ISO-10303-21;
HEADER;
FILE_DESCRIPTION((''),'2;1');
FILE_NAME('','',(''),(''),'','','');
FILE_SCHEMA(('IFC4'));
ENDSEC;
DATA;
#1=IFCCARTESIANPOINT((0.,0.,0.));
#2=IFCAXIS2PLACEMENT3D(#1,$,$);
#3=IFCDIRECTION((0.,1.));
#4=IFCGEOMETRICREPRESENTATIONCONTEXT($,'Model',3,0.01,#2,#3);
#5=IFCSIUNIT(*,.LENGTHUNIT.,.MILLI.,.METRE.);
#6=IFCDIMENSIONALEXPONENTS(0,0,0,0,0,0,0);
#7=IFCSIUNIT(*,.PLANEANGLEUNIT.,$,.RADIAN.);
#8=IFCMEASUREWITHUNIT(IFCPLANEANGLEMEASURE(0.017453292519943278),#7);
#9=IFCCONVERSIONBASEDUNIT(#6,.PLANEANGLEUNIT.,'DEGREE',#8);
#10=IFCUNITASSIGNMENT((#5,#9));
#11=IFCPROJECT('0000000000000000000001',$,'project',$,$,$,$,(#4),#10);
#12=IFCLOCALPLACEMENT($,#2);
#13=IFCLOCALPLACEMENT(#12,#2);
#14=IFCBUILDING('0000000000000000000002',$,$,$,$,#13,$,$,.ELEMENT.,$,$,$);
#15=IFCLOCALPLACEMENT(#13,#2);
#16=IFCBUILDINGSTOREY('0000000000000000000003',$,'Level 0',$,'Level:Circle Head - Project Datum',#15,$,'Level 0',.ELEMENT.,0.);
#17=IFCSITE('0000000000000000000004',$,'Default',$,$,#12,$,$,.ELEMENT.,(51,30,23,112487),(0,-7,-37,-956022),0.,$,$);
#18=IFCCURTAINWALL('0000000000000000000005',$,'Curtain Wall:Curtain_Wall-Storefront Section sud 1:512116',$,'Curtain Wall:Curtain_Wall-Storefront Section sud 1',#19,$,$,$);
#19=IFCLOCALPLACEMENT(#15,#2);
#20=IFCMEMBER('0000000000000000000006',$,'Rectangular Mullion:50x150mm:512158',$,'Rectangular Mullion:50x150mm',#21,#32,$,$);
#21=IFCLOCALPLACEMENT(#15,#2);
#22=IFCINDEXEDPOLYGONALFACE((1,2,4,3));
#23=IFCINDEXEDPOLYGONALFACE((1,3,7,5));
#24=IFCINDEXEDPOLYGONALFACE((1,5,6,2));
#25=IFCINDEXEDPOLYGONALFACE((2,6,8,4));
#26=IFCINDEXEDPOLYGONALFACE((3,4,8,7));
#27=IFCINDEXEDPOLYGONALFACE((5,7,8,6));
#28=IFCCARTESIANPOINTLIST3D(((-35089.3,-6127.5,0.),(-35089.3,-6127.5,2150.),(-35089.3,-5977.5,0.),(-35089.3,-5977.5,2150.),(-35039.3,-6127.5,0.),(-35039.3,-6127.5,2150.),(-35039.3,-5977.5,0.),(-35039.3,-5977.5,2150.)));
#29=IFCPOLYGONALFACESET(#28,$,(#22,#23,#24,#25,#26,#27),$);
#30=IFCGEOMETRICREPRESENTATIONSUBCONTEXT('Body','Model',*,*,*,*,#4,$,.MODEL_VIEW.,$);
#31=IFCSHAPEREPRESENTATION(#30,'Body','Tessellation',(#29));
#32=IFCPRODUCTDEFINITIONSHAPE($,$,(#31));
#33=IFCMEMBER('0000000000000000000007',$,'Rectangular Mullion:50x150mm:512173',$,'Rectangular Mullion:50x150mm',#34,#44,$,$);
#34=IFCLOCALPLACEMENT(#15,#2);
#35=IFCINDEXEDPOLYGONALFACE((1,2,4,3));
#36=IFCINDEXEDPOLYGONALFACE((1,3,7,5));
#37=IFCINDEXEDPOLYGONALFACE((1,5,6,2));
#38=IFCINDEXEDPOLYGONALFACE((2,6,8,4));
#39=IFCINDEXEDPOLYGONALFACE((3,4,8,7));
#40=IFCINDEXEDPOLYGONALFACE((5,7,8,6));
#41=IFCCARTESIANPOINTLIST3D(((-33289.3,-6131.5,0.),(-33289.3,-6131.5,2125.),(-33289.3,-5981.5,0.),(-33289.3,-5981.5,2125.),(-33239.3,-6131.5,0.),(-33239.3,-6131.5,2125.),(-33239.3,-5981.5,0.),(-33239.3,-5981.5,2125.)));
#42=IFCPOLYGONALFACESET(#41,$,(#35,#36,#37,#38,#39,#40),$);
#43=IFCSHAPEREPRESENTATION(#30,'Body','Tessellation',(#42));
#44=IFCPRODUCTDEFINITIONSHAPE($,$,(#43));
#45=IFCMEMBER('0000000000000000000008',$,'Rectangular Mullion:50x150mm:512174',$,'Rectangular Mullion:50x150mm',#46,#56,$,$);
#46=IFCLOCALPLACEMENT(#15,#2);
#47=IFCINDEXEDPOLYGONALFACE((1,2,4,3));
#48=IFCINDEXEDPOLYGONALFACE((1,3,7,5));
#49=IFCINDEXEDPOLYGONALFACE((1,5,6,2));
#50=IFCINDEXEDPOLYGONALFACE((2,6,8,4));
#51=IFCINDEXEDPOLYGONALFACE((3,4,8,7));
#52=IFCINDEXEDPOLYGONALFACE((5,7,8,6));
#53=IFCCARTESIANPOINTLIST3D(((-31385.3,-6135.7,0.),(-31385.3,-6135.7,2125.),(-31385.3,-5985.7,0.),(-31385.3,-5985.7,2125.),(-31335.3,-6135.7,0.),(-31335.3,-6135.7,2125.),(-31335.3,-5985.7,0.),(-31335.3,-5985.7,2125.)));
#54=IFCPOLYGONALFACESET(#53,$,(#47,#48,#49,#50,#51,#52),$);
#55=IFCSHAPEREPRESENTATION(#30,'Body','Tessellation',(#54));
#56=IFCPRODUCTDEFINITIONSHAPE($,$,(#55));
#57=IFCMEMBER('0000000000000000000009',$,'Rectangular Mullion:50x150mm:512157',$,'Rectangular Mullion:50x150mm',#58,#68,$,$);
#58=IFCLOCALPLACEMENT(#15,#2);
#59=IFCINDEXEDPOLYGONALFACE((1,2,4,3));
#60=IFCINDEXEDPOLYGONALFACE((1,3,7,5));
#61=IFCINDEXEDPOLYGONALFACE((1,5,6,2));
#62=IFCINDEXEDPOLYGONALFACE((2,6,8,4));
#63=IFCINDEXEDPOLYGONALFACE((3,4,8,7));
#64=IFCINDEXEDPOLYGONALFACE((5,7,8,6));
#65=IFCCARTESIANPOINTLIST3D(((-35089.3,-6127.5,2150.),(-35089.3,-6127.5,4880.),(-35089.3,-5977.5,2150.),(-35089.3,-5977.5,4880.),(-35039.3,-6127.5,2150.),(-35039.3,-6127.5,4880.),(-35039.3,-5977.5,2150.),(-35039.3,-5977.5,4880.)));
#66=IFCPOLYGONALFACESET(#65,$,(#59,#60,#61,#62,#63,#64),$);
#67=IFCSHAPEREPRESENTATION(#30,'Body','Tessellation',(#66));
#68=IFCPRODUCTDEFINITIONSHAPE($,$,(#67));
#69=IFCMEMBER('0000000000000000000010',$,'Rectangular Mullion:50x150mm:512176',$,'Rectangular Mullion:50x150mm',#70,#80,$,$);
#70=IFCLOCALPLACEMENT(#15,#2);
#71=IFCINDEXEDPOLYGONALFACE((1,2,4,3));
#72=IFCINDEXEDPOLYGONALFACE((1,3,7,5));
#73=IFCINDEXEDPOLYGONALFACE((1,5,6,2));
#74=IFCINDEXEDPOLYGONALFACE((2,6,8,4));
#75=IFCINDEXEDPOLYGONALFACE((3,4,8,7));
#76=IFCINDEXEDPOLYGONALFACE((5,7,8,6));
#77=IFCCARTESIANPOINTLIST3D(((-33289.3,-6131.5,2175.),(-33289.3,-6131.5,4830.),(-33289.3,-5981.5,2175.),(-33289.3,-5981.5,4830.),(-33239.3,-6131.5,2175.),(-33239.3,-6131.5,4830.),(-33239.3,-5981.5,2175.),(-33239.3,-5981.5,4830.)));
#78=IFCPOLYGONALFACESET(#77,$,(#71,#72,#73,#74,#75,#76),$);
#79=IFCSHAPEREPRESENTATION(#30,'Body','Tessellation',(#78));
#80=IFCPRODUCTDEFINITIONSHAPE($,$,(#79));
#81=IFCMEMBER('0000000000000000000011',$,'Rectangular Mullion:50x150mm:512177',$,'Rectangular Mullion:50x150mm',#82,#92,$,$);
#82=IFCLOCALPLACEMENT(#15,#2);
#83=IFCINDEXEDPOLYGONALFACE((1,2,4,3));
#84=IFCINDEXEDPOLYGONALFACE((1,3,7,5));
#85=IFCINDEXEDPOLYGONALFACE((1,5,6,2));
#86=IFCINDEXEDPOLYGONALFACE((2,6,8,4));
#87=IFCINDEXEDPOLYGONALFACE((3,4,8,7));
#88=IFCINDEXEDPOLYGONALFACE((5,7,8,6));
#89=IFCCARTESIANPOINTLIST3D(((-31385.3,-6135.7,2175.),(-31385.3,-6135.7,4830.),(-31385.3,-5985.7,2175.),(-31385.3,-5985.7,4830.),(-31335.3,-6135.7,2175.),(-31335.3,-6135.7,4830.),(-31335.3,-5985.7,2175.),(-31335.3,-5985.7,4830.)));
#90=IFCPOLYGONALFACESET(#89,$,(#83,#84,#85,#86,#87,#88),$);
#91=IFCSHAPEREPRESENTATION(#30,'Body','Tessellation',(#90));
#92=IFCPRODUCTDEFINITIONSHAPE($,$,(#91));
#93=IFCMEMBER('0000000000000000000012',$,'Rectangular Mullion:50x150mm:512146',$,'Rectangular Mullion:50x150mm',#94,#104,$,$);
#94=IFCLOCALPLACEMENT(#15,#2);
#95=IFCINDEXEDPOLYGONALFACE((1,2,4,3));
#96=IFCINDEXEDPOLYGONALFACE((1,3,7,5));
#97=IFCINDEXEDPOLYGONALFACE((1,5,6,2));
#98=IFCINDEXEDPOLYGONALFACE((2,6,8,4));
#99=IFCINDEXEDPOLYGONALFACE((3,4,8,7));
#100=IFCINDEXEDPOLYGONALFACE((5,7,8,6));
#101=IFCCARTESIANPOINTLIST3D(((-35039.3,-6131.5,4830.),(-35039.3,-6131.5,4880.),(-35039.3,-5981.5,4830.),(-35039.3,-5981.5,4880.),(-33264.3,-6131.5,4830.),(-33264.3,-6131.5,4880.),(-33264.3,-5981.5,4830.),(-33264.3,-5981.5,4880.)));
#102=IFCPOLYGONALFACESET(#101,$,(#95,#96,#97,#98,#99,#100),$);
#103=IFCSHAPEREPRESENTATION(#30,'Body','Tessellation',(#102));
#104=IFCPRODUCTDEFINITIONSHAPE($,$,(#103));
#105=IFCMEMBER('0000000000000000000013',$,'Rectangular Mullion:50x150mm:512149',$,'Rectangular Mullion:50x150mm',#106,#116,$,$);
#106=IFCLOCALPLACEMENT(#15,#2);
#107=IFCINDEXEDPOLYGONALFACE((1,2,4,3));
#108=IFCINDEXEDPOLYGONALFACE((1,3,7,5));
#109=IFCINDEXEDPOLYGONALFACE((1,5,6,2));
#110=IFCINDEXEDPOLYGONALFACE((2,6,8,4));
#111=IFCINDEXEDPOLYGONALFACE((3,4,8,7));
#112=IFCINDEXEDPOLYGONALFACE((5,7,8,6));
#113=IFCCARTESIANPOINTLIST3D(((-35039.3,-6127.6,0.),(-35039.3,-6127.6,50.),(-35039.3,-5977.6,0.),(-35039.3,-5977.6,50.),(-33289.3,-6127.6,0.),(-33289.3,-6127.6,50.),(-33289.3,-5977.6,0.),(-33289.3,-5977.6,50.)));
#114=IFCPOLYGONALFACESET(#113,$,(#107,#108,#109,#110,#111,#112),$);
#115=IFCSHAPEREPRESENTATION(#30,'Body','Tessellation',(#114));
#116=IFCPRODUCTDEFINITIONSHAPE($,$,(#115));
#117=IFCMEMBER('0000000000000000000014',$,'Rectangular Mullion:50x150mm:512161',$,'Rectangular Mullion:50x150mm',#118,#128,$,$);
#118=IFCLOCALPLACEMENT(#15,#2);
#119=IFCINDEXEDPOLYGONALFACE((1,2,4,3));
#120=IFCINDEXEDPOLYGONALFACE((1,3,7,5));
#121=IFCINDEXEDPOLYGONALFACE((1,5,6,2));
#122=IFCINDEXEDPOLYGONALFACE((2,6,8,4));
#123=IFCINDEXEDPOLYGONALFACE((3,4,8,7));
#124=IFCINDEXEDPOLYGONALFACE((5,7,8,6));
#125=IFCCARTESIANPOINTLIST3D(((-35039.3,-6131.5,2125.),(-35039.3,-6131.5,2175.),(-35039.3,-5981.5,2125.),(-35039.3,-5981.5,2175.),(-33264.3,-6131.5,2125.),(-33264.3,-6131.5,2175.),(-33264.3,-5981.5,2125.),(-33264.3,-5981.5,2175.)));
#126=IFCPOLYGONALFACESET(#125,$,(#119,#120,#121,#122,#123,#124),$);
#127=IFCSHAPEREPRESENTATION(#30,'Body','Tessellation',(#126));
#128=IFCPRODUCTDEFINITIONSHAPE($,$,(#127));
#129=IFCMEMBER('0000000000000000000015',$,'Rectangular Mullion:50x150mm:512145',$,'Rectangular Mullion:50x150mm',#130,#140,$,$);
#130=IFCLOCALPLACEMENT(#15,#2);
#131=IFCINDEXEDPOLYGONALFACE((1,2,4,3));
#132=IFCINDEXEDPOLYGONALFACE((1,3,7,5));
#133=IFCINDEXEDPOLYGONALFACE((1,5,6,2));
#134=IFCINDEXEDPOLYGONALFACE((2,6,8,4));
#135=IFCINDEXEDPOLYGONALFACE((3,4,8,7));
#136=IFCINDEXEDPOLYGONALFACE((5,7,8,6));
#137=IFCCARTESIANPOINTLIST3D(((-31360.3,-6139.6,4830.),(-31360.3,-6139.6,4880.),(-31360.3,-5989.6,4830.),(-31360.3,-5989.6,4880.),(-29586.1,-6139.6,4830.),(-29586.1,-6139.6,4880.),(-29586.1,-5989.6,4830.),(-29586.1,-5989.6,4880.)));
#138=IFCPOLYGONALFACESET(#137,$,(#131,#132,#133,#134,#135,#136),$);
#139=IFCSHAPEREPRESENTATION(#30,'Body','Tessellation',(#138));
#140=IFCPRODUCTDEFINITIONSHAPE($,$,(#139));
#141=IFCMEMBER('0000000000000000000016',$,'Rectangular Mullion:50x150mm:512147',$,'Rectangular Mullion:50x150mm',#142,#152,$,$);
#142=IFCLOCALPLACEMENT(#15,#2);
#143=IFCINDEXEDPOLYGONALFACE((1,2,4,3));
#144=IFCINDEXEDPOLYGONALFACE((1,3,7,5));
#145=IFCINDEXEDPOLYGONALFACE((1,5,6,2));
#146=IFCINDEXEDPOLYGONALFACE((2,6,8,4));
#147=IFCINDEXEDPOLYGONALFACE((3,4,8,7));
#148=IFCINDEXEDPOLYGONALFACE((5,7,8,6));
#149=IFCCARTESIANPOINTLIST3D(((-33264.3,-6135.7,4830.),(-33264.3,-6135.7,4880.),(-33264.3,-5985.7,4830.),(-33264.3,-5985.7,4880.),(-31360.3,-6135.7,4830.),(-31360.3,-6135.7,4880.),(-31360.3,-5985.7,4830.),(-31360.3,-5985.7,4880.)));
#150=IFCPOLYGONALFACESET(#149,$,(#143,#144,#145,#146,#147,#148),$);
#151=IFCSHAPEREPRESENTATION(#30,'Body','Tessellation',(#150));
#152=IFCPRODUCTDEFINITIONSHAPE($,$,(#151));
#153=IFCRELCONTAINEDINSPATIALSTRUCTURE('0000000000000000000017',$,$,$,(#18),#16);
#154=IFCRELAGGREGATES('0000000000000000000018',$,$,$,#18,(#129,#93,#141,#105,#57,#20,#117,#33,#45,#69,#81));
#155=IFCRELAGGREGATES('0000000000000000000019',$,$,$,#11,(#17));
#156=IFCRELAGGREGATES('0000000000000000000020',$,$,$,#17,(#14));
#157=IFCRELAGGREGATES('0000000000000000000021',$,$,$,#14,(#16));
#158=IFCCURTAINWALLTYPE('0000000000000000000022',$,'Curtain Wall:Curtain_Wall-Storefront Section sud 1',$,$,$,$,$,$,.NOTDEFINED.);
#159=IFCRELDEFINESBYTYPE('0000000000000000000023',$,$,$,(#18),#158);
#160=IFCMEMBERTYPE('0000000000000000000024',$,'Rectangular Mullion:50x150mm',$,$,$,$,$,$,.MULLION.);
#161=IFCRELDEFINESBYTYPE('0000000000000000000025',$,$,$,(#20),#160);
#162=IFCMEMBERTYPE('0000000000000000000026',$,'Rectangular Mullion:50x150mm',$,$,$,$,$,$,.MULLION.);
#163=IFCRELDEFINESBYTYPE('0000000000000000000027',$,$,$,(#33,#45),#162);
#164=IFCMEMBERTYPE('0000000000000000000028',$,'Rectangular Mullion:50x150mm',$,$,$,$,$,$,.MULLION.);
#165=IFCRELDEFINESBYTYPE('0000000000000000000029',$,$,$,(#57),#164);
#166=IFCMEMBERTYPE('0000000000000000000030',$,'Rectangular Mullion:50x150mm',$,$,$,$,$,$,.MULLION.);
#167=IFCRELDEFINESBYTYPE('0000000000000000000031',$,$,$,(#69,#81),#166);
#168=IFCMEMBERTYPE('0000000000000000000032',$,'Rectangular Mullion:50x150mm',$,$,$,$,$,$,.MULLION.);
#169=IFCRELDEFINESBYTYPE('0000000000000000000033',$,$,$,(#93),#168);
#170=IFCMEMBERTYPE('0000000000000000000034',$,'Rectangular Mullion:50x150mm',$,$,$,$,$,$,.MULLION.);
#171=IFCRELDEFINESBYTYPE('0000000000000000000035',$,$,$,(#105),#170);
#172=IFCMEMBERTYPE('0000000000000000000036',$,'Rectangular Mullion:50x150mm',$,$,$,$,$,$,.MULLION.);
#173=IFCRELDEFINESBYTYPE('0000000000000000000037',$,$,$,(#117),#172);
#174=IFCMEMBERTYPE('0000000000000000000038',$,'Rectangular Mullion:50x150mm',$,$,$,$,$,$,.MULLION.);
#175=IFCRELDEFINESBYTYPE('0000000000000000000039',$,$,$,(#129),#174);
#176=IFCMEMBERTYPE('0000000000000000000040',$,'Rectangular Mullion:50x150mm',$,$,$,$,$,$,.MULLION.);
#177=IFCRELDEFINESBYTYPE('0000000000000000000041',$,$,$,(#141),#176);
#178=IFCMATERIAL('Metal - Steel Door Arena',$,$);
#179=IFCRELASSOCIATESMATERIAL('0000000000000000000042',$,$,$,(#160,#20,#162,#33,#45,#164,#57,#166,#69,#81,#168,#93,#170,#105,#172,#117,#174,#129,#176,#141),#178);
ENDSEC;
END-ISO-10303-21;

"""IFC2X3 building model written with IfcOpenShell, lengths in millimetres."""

from ifc_helpers import new_model, entity, si_unit, converted_unit, direction, frame, origin, origin_2d_with_axis, place, context, subcontext, project, spatial, rectangle, extrude, source, transform, mapped, material, type_object, type_shapes, element, aggregate, save


model = new_model("IFC2X3")

# Units and contexts
model_context = context("Model", 3, precision=0.01, world=origin(), true_north=direction((0.0, 1.0)))
body_context = subcontext(model_context, "Body", "Model", "MODEL_VIEW")
ifc_project = project(units=[si_unit("LENGTHUNIT", "METRE", prefix="MILLI"), converted_unit("PLANEANGLEUNIT", "DEGREE", entity("IfcPlaneAngleMeasure", 0.017453292519943278), si_unit("PLANEANGLEUNIT", "RADIAN"), dimensions=[0, 0, 0, 0, 0, 0, 0])], contexts=[model_context])

# Site, building, storey
site_placement = place(None, origin())
site = spatial("IfcSite", under=ifc_project, at=site_placement, Name="Default", CompositionType="ELEMENT", RefLatitude=(51, 30, 23, 112487), RefLongitude=(0, -7, -37, -956022), RefElevation=0.0)
building_placement = place(site_placement, origin())
building = spatial("IfcBuilding", under=site, at=building_placement, CompositionType="ELEMENT")
storey_placement = place(building_placement, origin())
storey = spatial("IfcBuildingStorey", under=building, at=storey_placement, Name="Level 0", ObjectType="Level:Circle Head - Project Datum", LongName="Level 0", CompositionType="ELEMENT", Elevation=0.0)

# Curtain wall, members
curtain_wall_type = type_object("IfcCurtainWallType", Name="Curtain Wall:Curtain_Wall-Storefront Section sud 1", PredefinedType="NOTDEFINED")
curtain_wall_placement = place(storey_placement, origin())
curtain_wall = element("IfcCurtainWall", 1, at=curtain_wall_placement, inside=storey, type_object=curtain_wall_type, Name="Curtain Wall:Curtain_Wall-Storefront Section sud 1:512116", ObjectType="Curtain Wall:Curtain_Wall-Storefront Section sud 1")
ifc_material_1 = material(Name="Metal - Steel Door Arena")
member_type_1 = type_object("IfcMemberType", Name="Rectangular Mullion:50x150mm", PredefinedType="MULLION", material=ifc_material_1)
shared_shape_1 = source(origin(), body_context, "Body", "SweptSolid", [
    extrude(rectangle(XDim=50.0, YDim=150.0, at=origin_2d_with_axis()), frame((-25.0, 0.0, -2150.0), z_axis=(0.0, 0.0, 1.0), x_axis=(-1.0, 0.0, 0.0)), (0.0, 0.0, 1.0), 2150.0),
])
type_shapes(member_type_1, [shared_shape_1])
member_1_placement = place(curtain_wall_placement, frame((-35089.3, -6052.5, 2150.0), z_axis=(0.0, 0.0, 1.0), x_axis=(-1.0, 0.0, 0.0)))
member_1 = element("IfcMember", 2, at=member_1_placement, type_object=member_type_1, material=ifc_material_1, Name="Rectangular Mullion:50x150mm:512158", ObjectType="Rectangular Mullion:50x150mm", context=body_context, shape_type="MappedRepresentation", body=[
    mapped(shared_shape_1, transform((0.0, 0.0, 0.0), scale=1.0)),
])
member_type_2 = type_object("IfcMemberType", Name="Rectangular Mullion:50x150mm", PredefinedType="MULLION", material=ifc_material_1)
shared_shape_2 = source(origin(), body_context, "Body", "SweptSolid", [
    extrude(rectangle(XDim=50.0, YDim=150.0, at=origin_2d_with_axis()), frame((0.0, 0.0, -2125.0), z_axis=(0.0, 0.0, 1.0), x_axis=(-1.0, 0.0, 0.0)), (0.0, 0.0, 1.0), 2125.0),
])
type_shapes(member_type_2, [shared_shape_2])
member_2_placement = place(curtain_wall_placement, frame((-33264.3, -6056.5, 0.0), z_axis=(0.0, 0.0, -1.0), x_axis=(1.0, 0.0, 0.0)))
member_2 = element("IfcMember", 3, at=member_2_placement, type_object=member_type_2, material=ifc_material_1, Name="Rectangular Mullion:50x150mm:512173", ObjectType="Rectangular Mullion:50x150mm", context=body_context, shape_type="MappedRepresentation", body=[
    mapped(shared_shape_2, transform((0.0, 0.0, 0.0), scale=1.0)),
])
member_3_placement = place(curtain_wall_placement, frame((-31360.3, -6060.7, 0.0), z_axis=(0.0, 0.0, -1.0), x_axis=(1.0, 0.0, 0.0)))
member_3 = element("IfcMember", 4, at=member_3_placement, type_object=member_type_2, material=ifc_material_1, Name="Rectangular Mullion:50x150mm:512174", ObjectType="Rectangular Mullion:50x150mm", context=body_context, shape_type="MappedRepresentation", body=[
    mapped(shared_shape_2, transform((0.0, 0.0, 0.0), scale=1.0)),
])
member_type_3 = type_object("IfcMemberType", Name="Rectangular Mullion:50x150mm", PredefinedType="MULLION", material=ifc_material_1)
shared_shape_3 = source(origin(), body_context, "Body", "SweptSolid", [
    extrude(rectangle(XDim=50.0, YDim=150.0, at=origin_2d_with_axis()), frame((-25.0, 0.0, -2730.0), z_axis=(0.0, 0.0, 1.0), x_axis=(-1.0, 0.0, 0.0)), (0.0, 0.0, 1.0), 2730.0),
])
type_shapes(member_type_3, [shared_shape_3])
member_4_placement = place(curtain_wall_placement, frame((-35089.3, -6052.5, 4880.0), z_axis=(0.0, 0.0, 1.0), x_axis=(-1.0, 0.0, 0.0)))
member_4 = element("IfcMember", 5, at=member_4_placement, type_object=member_type_3, material=ifc_material_1, Name="Rectangular Mullion:50x150mm:512157", ObjectType="Rectangular Mullion:50x150mm", context=body_context, shape_type="MappedRepresentation", body=[
    mapped(shared_shape_3, transform((0.0, 0.0, 0.0), scale=1.0)),
])
member_type_4 = type_object("IfcMemberType", Name="Rectangular Mullion:50x150mm", PredefinedType="MULLION", material=ifc_material_1)
shared_shape_4 = source(origin(), body_context, "Body", "SweptSolid", [
    extrude(rectangle(XDim=50.0, YDim=150.0, at=origin_2d_with_axis()), frame((0.0, 0.0, -2655.0), z_axis=(0.0, 0.0, 1.0), x_axis=(-1.0, 0.0, 0.0)), (0.0, 0.0, 1.0), 2655.0),
])
type_shapes(member_type_4, [shared_shape_4])
member_5_placement = place(curtain_wall_placement, frame((-33264.3, -6056.5, 2175.0), z_axis=(0.0, 0.0, -1.0), x_axis=(1.0, 0.0, 0.0)))
member_5 = element("IfcMember", 6, at=member_5_placement, type_object=member_type_4, material=ifc_material_1, Name="Rectangular Mullion:50x150mm:512176", ObjectType="Rectangular Mullion:50x150mm", context=body_context, shape_type="MappedRepresentation", body=[
    mapped(shared_shape_4, transform((0.0, 0.0, 0.0), scale=1.0)),
])
member_6_placement = place(curtain_wall_placement, frame((-31360.3, -6060.7, 2175.0), z_axis=(0.0, 0.0, -1.0), x_axis=(1.0, 0.0, 0.0)))
member_6 = element("IfcMember", 7, at=member_6_placement, type_object=member_type_4, material=ifc_material_1, Name="Rectangular Mullion:50x150mm:512177", ObjectType="Rectangular Mullion:50x150mm", context=body_context, shape_type="MappedRepresentation", body=[
    mapped(shared_shape_4, transform((0.0, 0.0, 0.0), scale=1.0)),
])
member_type_5 = type_object("IfcMemberType", Name="Rectangular Mullion:50x150mm", PredefinedType="MULLION", material=ifc_material_1)
shared_shape_5 = source(origin(), body_context, "Body", "SweptSolid", [
    extrude(rectangle(XDim=50.0, YDim=150.0, at=origin_2d_with_axis()), frame((-25.0, 0.0, -1775.0), z_axis=(0.0, 0.0, 1.0), x_axis=(-1.0, 0.0, 0.0)), (0.0, 0.0, 1.0), 1775.0),
])
type_shapes(member_type_5, [shared_shape_5])
member_7_placement = place(curtain_wall_placement, frame((-33264.3, -6056.5, 4880.0), z_axis=(1.0, 0.0, 0.0), x_axis=(0.0, 0.0, 1.0)))
member_7 = element("IfcMember", 8, at=member_7_placement, type_object=member_type_5, material=ifc_material_1, Name="Rectangular Mullion:50x150mm:512146", ObjectType="Rectangular Mullion:50x150mm", context=body_context, shape_type="MappedRepresentation", body=[
    mapped(shared_shape_5, transform((0.0, 0.0, 0.0), scale=1.0)),
])
member_type_6 = type_object("IfcMemberType", Name="Rectangular Mullion:50x150mm", PredefinedType="MULLION", material=ifc_material_1)
shared_shape_6 = source(origin(), body_context, "Body", "SweptSolid", [
    extrude(rectangle(XDim=50.0, YDim=150.0, at=origin_2d_with_axis()), frame((-25.0, 0.0, -1750.0), z_axis=(0.0, 0.0, 1.0), x_axis=(-1.0, 0.0, 0.0)), (0.0, 0.0, 1.0), 1750.0),
])
type_shapes(member_type_6, [shared_shape_6])
member_8_placement = place(curtain_wall_placement, frame((-35039.3, -6052.6, 0.0), z_axis=(-1.0, 0.0, 0.0), x_axis=(0.0, 0.0, -1.0)))
member_8 = element("IfcMember", 9, at=member_8_placement, type_object=member_type_6, material=ifc_material_1, Name="Rectangular Mullion:50x150mm:512149", ObjectType="Rectangular Mullion:50x150mm", context=body_context, shape_type="MappedRepresentation", body=[
    mapped(shared_shape_6, transform((0.0, 0.0, 0.0), scale=1.0)),
])
member_type_7 = type_object("IfcMemberType", Name="Rectangular Mullion:50x150mm", PredefinedType="MULLION", material=ifc_material_1)
shared_shape_7 = source(origin(), body_context, "Body", "SweptSolid", [
    extrude(rectangle(XDim=50.0, YDim=150.0, at=origin_2d_with_axis()), frame((0.0, 0.0, -1775.0), z_axis=(0.0, 0.0, 1.0), x_axis=(-1.0, 0.0, 0.0)), (0.0, 0.0, 1.0), 1775.0),
])
type_shapes(member_type_7, [shared_shape_7])
member_9_placement = place(curtain_wall_placement, frame((-33264.3, -6056.5, 2150.0), z_axis=(1.0, 0.0, 0.0), x_axis=(0.0, 0.0, 1.0)))
member_9 = element("IfcMember", 10, at=member_9_placement, type_object=member_type_7, material=ifc_material_1, Name="Rectangular Mullion:50x150mm:512161", ObjectType="Rectangular Mullion:50x150mm", context=body_context, shape_type="MappedRepresentation", body=[
    mapped(shared_shape_7, transform((0.0, 0.0, 0.0), scale=1.0)),
])
member_type_8 = type_object("IfcMemberType", Name="Rectangular Mullion:50x150mm", PredefinedType="MULLION", material=ifc_material_1)
shared_shape_8 = source(origin(), body_context, "Body", "SweptSolid", [
    extrude(rectangle(XDim=50.0, YDim=150.0, at=origin_2d_with_axis()), frame((-25.0, 0.0, -1774.2), z_axis=(0.0, 0.0, 1.0), x_axis=(-1.0, 0.0, 0.0)), (0.0, 0.0, 1.0), 1774.2),
])
type_shapes(member_type_8, [shared_shape_8])
member_10_placement = place(curtain_wall_placement, frame((-29586.1, -6064.6, 4880.0), z_axis=(1.0, 0.0, 0.0), x_axis=(0.0, 0.0, 1.0)))
member_10 = element("IfcMember", 11, at=member_10_placement, type_object=member_type_8, material=ifc_material_1, Name="Rectangular Mullion:50x150mm:512145", ObjectType="Rectangular Mullion:50x150mm", context=body_context, shape_type="MappedRepresentation", body=[
    mapped(shared_shape_8, transform((0.0, 0.0, 0.0), scale=1.0)),
])
member_type_9 = type_object("IfcMemberType", Name="Rectangular Mullion:50x150mm", PredefinedType="MULLION", material=ifc_material_1)
shared_shape_9 = source(origin(), body_context, "Body", "SweptSolid", [
    extrude(rectangle(XDim=50.0, YDim=150.0, at=origin_2d_with_axis()), frame((-25.0, 0.0, -1904.0), z_axis=(0.0, 0.0, 1.0), x_axis=(-1.0, 0.0, 0.0)), (0.0, 0.0, 1.0), 1904.0),
])
type_shapes(member_type_9, [shared_shape_9])
member_11_placement = place(curtain_wall_placement, frame((-31360.3, -6060.7, 4880.0), z_axis=(1.0, 0.0, 0.0), x_axis=(0.0, 0.0, 1.0)))
member_11 = element("IfcMember", 12, at=member_11_placement, type_object=member_type_9, material=ifc_material_1, Name="Rectangular Mullion:50x150mm:512147", ObjectType="Rectangular Mullion:50x150mm", context=body_context, shape_type="MappedRepresentation", body=[
    mapped(shared_shape_9, transform((0.0, 0.0, 0.0), scale=1.0)),
])
aggregate(curtain_wall, [member_10, member_7, member_11, member_8, member_4, member_1, member_9, member_2, member_3, member_5, member_6])

save(model, "model.ifc")
